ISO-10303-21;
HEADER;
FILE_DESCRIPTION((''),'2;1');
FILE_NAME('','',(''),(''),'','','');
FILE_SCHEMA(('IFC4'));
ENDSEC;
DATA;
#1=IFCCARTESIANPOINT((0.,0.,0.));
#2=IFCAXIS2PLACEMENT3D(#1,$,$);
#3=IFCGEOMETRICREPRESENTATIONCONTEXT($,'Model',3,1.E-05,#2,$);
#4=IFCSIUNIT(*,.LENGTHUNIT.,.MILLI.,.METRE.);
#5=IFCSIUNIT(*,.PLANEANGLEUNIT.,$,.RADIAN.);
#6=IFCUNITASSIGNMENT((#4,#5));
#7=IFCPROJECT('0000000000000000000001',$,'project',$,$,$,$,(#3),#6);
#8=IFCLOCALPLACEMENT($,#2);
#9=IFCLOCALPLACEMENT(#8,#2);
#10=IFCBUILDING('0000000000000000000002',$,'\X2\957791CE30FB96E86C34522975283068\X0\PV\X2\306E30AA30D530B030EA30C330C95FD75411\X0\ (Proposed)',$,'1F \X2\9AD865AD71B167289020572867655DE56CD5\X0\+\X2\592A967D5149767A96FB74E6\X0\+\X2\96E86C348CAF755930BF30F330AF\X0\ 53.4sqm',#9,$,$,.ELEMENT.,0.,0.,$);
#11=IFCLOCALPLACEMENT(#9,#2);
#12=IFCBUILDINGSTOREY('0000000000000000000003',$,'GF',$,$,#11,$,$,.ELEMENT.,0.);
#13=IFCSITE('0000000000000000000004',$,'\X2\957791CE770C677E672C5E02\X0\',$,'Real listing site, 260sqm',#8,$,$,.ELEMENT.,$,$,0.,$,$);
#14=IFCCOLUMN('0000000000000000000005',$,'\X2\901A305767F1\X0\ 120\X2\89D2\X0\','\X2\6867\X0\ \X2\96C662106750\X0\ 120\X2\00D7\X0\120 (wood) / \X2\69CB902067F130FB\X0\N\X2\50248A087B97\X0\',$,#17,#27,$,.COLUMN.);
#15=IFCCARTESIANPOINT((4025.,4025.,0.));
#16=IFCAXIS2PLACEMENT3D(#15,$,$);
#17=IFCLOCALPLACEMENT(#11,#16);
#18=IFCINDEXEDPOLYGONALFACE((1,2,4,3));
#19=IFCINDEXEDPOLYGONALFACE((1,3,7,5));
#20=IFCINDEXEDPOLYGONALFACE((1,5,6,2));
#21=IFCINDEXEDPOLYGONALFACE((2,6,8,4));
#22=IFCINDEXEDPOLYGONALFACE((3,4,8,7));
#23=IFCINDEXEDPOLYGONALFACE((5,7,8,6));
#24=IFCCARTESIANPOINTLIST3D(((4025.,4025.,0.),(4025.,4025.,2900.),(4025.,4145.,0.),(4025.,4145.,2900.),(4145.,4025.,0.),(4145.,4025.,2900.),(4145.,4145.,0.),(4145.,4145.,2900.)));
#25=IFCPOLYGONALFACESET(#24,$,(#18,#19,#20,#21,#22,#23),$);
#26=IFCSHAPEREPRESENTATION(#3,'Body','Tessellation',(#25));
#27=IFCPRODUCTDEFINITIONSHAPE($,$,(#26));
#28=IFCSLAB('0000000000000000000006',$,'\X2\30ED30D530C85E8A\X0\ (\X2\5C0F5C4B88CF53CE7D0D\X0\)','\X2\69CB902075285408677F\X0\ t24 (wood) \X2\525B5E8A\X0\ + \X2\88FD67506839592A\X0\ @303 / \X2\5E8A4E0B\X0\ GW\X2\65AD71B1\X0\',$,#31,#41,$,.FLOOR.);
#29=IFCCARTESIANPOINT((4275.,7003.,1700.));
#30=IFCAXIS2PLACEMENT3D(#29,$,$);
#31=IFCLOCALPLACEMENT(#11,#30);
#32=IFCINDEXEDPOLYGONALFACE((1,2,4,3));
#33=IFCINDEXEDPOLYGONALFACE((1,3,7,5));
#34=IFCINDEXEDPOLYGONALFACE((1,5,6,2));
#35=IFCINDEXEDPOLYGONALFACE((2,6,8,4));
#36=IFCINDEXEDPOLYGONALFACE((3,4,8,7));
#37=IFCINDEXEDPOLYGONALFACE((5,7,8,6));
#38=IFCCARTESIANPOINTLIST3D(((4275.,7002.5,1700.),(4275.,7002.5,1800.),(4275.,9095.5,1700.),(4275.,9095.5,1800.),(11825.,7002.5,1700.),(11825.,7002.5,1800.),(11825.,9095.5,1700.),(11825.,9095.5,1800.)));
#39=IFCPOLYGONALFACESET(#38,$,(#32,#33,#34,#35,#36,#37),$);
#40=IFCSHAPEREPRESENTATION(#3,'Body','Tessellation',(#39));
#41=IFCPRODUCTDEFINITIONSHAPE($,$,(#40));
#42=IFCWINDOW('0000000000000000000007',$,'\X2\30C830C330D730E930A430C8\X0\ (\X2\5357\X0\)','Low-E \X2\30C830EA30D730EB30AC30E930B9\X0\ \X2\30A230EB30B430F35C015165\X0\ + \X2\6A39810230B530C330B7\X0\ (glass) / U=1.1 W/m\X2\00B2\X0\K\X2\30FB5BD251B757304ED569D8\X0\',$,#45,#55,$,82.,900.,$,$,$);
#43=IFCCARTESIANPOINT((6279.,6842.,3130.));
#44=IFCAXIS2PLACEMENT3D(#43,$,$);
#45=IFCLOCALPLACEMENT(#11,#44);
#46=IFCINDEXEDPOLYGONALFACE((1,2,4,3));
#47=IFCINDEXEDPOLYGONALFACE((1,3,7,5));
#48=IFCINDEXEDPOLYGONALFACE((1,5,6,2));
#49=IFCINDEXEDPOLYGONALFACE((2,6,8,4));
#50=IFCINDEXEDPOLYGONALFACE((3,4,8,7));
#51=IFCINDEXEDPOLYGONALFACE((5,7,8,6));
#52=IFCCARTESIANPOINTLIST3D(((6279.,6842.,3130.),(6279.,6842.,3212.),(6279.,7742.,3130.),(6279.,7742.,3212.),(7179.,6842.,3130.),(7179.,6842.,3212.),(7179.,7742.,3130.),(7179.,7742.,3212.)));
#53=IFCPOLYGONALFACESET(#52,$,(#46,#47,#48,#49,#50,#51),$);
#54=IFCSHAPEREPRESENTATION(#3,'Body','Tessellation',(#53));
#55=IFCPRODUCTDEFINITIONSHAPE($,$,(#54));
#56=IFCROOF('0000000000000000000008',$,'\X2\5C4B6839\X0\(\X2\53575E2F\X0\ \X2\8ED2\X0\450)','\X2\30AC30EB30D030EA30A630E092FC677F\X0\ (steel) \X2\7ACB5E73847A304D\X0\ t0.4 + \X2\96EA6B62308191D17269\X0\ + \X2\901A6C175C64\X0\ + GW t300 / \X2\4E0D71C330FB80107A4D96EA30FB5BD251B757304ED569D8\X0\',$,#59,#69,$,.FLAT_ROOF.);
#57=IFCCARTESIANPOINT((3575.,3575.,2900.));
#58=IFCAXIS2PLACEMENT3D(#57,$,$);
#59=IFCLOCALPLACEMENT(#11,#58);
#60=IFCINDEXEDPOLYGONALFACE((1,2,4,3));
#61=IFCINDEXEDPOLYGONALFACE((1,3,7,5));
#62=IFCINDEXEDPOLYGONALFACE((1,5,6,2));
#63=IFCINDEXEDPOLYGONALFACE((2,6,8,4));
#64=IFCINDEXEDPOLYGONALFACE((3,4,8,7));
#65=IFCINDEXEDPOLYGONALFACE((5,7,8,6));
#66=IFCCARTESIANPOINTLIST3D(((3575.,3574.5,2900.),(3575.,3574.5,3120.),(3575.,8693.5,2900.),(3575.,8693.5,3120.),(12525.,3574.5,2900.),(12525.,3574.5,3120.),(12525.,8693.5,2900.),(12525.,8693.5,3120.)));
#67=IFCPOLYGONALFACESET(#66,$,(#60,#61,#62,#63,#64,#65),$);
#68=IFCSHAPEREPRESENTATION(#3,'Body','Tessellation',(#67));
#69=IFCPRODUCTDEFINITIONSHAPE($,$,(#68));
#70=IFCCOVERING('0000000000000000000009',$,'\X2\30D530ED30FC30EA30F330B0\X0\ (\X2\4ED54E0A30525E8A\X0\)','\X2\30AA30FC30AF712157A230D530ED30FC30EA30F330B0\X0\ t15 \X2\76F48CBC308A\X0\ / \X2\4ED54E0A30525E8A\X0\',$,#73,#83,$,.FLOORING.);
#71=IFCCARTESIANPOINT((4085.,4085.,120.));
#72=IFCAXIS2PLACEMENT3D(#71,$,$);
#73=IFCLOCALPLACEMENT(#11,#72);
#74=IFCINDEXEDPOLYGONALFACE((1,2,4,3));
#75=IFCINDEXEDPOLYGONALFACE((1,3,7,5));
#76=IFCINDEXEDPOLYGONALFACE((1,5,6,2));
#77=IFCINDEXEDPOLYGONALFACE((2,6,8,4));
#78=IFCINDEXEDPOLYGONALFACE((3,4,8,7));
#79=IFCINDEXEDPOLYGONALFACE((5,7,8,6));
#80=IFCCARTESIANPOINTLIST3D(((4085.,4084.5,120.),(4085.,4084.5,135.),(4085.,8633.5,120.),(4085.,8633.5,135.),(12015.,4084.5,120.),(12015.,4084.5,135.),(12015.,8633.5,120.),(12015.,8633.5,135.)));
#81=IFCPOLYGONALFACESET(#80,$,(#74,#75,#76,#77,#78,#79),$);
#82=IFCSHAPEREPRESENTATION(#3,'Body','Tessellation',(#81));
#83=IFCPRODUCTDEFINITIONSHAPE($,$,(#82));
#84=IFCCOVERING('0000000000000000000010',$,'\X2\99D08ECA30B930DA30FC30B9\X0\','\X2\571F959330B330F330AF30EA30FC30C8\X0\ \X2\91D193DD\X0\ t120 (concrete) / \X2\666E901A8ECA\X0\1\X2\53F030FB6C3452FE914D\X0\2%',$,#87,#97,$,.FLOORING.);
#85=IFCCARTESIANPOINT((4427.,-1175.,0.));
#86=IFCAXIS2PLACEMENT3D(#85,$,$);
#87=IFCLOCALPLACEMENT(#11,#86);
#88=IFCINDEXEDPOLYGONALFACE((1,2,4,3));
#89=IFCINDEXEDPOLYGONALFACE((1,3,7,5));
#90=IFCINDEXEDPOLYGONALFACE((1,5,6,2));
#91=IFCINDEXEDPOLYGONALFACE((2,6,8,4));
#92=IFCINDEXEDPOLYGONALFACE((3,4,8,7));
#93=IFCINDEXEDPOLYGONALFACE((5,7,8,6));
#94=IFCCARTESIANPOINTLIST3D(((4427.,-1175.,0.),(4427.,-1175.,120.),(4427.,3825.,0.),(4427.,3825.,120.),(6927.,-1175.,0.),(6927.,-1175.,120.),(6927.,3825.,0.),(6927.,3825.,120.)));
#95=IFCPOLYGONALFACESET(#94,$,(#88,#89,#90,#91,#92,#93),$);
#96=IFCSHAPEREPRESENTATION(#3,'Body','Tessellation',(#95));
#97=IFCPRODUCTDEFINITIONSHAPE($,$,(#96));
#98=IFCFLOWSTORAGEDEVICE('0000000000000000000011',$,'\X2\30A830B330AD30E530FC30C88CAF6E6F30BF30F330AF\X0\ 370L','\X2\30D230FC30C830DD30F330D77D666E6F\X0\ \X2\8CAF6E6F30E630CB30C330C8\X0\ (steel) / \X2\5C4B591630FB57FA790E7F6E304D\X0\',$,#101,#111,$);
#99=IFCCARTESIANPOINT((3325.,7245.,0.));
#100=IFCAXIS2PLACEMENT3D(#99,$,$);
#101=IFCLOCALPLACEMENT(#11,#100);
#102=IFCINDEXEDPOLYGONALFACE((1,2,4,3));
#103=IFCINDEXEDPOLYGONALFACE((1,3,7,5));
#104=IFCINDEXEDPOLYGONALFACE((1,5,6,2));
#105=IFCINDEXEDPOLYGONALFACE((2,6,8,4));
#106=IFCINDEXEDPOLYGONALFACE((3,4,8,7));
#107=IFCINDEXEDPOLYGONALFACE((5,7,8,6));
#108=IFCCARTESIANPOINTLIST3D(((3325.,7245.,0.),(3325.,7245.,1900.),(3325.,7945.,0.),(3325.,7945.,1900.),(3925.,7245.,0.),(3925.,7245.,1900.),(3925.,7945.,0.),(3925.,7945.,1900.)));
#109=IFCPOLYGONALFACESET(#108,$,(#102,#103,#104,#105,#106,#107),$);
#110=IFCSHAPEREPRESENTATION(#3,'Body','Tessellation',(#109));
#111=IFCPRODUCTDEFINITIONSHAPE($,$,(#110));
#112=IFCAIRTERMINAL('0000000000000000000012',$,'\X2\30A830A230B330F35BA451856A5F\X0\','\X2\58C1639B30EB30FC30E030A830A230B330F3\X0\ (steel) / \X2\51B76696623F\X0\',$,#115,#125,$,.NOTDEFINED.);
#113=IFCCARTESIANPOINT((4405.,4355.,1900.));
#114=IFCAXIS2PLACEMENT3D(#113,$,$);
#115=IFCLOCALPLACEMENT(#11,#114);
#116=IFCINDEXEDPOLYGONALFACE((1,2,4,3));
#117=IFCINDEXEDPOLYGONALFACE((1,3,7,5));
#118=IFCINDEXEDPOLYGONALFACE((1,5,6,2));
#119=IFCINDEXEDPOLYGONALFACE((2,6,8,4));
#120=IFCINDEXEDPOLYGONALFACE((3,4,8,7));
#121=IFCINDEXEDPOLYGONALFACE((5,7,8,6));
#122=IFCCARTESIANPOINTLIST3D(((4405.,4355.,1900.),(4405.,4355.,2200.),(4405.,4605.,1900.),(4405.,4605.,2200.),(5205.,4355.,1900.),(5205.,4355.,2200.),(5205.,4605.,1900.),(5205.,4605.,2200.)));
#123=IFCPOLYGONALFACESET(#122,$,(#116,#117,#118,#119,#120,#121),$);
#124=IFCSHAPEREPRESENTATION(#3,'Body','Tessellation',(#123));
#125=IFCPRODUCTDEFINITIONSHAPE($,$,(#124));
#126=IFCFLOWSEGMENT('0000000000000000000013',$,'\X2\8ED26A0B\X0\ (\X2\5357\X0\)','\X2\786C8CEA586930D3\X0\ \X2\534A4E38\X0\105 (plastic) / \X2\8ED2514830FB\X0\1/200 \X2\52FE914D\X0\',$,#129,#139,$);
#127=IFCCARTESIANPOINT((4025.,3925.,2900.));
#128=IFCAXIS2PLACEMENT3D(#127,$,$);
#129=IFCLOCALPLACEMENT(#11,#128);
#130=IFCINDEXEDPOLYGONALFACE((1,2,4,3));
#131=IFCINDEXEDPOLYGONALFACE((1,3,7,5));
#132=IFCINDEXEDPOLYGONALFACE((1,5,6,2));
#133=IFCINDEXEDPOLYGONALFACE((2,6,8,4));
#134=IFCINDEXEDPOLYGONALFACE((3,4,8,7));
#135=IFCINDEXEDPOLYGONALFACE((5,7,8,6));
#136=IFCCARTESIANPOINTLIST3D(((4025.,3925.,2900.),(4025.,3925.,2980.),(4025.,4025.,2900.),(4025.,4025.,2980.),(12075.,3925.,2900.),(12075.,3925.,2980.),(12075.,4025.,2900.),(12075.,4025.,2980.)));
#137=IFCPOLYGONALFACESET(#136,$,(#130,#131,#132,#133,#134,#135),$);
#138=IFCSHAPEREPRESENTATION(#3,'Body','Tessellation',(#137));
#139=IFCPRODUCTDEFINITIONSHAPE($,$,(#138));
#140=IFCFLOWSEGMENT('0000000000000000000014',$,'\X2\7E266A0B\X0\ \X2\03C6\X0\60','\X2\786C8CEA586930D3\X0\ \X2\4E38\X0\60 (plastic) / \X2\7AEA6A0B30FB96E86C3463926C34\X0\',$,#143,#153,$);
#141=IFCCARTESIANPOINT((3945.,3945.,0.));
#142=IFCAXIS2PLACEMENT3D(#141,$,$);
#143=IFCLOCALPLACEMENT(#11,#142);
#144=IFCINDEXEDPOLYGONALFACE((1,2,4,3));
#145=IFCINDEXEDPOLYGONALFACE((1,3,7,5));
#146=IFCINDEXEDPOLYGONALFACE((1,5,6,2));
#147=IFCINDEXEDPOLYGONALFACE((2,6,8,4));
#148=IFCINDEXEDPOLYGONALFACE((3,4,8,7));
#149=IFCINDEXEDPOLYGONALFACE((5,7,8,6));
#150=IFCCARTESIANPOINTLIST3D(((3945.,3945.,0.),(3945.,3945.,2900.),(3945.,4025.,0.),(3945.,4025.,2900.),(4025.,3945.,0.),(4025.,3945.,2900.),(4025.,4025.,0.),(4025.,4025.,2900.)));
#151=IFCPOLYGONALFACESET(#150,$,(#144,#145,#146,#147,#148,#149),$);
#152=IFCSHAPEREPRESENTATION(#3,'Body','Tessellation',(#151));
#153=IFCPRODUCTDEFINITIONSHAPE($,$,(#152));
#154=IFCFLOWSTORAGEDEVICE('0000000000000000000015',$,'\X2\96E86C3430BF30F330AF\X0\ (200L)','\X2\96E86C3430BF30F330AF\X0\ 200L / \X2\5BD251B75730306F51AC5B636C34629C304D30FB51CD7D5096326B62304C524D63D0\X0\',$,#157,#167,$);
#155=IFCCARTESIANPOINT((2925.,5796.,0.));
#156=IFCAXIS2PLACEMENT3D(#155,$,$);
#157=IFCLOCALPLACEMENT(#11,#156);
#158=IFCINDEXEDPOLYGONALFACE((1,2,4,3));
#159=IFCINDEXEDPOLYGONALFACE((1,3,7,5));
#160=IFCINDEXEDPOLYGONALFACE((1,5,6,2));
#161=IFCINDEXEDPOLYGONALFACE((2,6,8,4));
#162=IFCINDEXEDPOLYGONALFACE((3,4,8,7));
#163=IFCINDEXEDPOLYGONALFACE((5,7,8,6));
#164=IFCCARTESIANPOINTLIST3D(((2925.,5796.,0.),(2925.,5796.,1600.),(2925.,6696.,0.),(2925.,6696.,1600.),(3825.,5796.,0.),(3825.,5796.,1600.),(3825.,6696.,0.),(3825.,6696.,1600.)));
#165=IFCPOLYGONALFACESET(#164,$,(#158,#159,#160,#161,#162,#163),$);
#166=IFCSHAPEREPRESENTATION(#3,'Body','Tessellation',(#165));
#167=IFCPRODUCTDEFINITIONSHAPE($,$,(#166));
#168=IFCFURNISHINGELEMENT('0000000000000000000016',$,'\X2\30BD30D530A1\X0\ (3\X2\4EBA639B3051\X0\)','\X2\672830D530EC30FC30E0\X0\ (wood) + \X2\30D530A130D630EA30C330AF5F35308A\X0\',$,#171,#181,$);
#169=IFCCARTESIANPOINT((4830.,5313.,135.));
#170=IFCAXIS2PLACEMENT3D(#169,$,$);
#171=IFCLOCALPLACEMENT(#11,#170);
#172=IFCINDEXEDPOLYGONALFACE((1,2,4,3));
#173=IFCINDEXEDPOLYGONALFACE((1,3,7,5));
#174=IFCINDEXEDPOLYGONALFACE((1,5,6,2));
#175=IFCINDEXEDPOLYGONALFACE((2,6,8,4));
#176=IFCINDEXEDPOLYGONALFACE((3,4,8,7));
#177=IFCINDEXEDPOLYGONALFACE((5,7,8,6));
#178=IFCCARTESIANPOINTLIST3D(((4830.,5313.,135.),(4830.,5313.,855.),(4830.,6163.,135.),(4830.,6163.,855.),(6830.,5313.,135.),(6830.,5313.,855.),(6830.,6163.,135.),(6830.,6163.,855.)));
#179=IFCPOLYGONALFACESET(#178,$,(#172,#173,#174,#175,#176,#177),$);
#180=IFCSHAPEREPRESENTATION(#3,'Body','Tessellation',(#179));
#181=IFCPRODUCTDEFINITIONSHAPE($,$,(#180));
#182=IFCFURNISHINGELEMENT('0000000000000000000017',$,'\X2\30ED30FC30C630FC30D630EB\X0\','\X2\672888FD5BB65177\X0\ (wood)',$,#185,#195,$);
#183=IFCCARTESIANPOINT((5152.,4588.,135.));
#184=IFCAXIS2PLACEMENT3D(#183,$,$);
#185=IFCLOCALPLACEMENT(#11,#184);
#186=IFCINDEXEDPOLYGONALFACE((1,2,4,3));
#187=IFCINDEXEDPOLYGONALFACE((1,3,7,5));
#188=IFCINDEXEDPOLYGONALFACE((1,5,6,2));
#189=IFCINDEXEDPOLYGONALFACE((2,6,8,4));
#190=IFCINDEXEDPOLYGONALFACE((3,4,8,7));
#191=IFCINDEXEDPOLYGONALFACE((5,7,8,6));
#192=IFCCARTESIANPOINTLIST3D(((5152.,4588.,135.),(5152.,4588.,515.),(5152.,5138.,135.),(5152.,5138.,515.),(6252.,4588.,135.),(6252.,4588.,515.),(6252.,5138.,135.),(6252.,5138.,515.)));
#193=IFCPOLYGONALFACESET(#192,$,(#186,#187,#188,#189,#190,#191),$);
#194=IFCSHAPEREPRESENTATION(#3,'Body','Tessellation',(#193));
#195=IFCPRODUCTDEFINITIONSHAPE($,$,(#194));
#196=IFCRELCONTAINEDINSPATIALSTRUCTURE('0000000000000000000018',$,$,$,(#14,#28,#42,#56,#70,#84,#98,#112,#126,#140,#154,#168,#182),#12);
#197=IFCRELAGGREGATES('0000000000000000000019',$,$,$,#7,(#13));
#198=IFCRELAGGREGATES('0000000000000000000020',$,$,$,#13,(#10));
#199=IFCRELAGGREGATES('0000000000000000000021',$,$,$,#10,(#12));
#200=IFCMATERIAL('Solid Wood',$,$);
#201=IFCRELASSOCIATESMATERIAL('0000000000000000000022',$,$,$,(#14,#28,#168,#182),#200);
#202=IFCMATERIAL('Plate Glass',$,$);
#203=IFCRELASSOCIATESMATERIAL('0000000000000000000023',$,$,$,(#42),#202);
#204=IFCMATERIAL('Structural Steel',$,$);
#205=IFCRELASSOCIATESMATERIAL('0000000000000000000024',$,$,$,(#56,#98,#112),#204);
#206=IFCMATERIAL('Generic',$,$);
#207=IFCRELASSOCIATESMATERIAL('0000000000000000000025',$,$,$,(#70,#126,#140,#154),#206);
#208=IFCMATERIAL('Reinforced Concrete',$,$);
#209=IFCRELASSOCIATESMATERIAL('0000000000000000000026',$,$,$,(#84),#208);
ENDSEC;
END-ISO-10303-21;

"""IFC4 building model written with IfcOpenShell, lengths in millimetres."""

from ifc_helpers import new_model, si_unit, frame, frame_2d, origin, place, context, project, spatial, rectangle, extrude, material, element, save


model = new_model("IFC4")

# Units and contexts
model_context = context("Model", 3, precision=1e-05, world=origin())
ifc_project = project(units=[si_unit("LENGTHUNIT", "METRE", prefix="MILLI"), si_unit("PLANEANGLEUNIT", "RADIAN")], contexts=[model_context])

# Site, building, storey
site_placement = place(None, origin())
site = spatial("IfcSite", under=ifc_project, at=site_placement, Name="長野県松本市", ObjectType="Real listing site, 260sqm", CompositionType="ELEMENT", RefElevation=0.0)
building_placement = place(site_placement, origin())
building = spatial("IfcBuilding", under=site, at=building_placement, Name="長野・雨水利用とPVのオフグリッド志向 (Proposed)", ObjectType="1F 高断熱木造在来工法+太陽光発電瓦+雨水貯留タンク 53.4sqm", CompositionType="ELEMENT", ElevationOfRefHeight=0.0, ElevationOfTerrain=0.0)
storey_placement = place(building_placement, origin())
storey = spatial("IfcBuildingStorey", under=building, at=storey_placement, Name="GF", CompositionType="ELEMENT", Elevation=0.0)

# Column
ifc_material_1 = material(Name="Solid Wood")
column_1_placement = place(storey_placement, frame((4025.0, 4025.0, 0.0)))
element("IfcColumn", 1, at=column_1_placement, inside=storey, material=ifc_material_1, Name="通し柱 120角", Description="桧 集成材 120×120 (wood) / 構造柱・N値計算", PredefinedType="COLUMN", context=model_context, shape_type="SweptSolid", body=[
    extrude(rectangle(XDim=120.0, YDim=120.0, at=frame_2d((60.0, 60.0))), frame((4025.0, 4025.0, 0.0)), (0.0, 0.0, 1.0), 2900.0),
])

# Slab
ifc_material_2 = material(Name="Reinforced Concrete")
slab_1_placement = place(storey_placement, frame((4275.0, 7003.0, 1700.0)))
element("IfcSlab", 2, at=slab_1_placement, inside=storey, material=ifc_material_1, Name="ロフト床 (小屋裏収納)", Description="構造用合板 t24 (wood) 剛床 + 製材根太 @303 / 床下 GW断熱", PredefinedType="FLOOR", context=model_context, shape_type="SweptSolid", body=[
    extrude(rectangle(XDim=7550.0, YDim=2093.0, at=frame_2d((3775.0, 1046.0))), frame((4275.0, 7003.0, 1700.0)), (0.0, 0.0, 1.0), 100.0),
])

# Shared definitions
ifc_material_3 = material(Name="Plate Glass")

# Window
window_1_placement = place(storey_placement, frame((6279.0, 6842.0, 3130.0)))
element("IfcWindow", 3, at=window_1_placement, inside=storey, material=ifc_material_3, Name="トップライト (南)", Description="Low-E トリプルガラス アルゴン封入 + 樹脂サッシ (glass) / U=1.1 W/m²K・寒冷地仕様", OverallHeight=82.0, OverallWidth=900.0, context=model_context, shape_type="SweptSolid", body=[
    extrude(rectangle(XDim=900.0, YDim=900.0, at=frame_2d((450.0, 450.0))), frame((6279.0, 6842.0, 3130.0)), (0.0, 0.0, 1.0), 82.0),
])

# Roof
ifc_material_4 = material(Name="Structural Steel")
roof_placement = place(storey_placement, frame((3575.0, 3575.0, 2900.0)))
element("IfcRoof", 4, at=roof_placement, inside=storey, material=ifc_material_4, Name="屋根(南帯 軒450)", Description="ガルバリウム鋼板 (steel) 立平葺き t0.4 + 雪止め金物 + 通気層 + GW t300 / 不燃・耐積雪・寒冷地仕様", PredefinedType="FLAT_ROOF", context=model_context, shape_type="SweptSolid", body=[
    extrude(rectangle(XDim=8950.0, YDim=5119.0, at=frame_2d((4475.0, 2559.0))), frame((3575.0, 3575.0, 2900.0)), (0.0, 0.0, 1.0), 220.0),
])

# Coverings
ifc_material_5 = material(Name="Generic")
covering_1_placement = place(storey_placement, frame((4085.0, 4085.0, 120.0)))
element("IfcCovering", 5, at=covering_1_placement, inside=storey, material=ifc_material_5, Name="フローリング (仕上げ床)", Description="オーク無垢フローリング t15 直貼り / 仕上げ床", PredefinedType="FLOORING", context=model_context, shape_type="SweptSolid", body=[
    extrude(rectangle(XDim=7930.0, YDim=4549.0, at=frame_2d((3965.0, 2274.0))), frame((4085.0, 4085.0, 120.0)), (0.0, 0.0, 1.0), 15.0),
])
covering_2_placement = place(storey_placement, frame((4427.0, -1175.0, 0.0)))
element("IfcCovering", 6, at=covering_2_placement, inside=storey, material=ifc_material_2, Name="駐車スペース", Description="土間コンクリート 金鏝 t120 (concrete) / 普通車1台・水勾配2%", PredefinedType="FLOORING", context=model_context, shape_type="SweptSolid", body=[
    extrude(rectangle(XDim=2500.0, YDim=5000.0, at=frame_2d((1250.0, 2500.0))), frame((4427.0, -1175.0, 0.0)), (0.0, 0.0, 1.0), 120.0),
])

# Flow storage device
flow_storage_device_1_placement = place(storey_placement, frame((3325.0, 7245.0, 0.0)))
element("IfcFlowStorageDevice", 7, at=flow_storage_device_1_placement, inside=storey, material=ifc_material_4, Name="エコキュート貯湯タンク 370L", Description="ヒートポンプ給湯 貯湯ユニット (steel) / 屋外・基礎置き", context=model_context, shape_type="SweptSolid", body=[
    extrude(rectangle(XDim=600.0, YDim=700.0, at=frame_2d((300.0, 350.0))), frame((3325.0, 7245.0, 0.0)), (0.0, 0.0, 1.0), 1900.0),
])

# Air terminal
air_terminal_placement = place(storey_placement, frame((4405.0, 4355.0, 1900.0)))
element("IfcAirTerminal", 8, at=air_terminal_placement, inside=storey, material=ifc_material_4, Name="エアコン室内機", Description="壁掛ルームエアコン (steel) / 冷暖房", PredefinedType="NOTDEFINED", context=model_context, shape_type="SweptSolid", body=[
    extrude(rectangle(XDim=800.0, YDim=250.0, at=frame_2d((400.0, 125.0))), frame((4405.0, 4355.0, 1900.0)), (0.0, 0.0, 1.0), 300.0),
])

# Flow segments
flow_segment_1_placement = place(storey_placement, frame((4025.0, 3925.0, 2900.0)))
element("IfcFlowSegment", 9, at=flow_segment_1_placement, inside=storey, material=ifc_material_5, Name="軒樋 (南)", Description="硬質塩ビ 半丸105 (plastic) / 軒先・1/200 勾配", context=model_context, shape_type="SweptSolid", body=[
    extrude(rectangle(XDim=8050.0, YDim=100.0, at=frame_2d((4025.0, 50.0))), frame((4025.0, 3925.0, 2900.0)), (0.0, 0.0, 1.0), 80.0),
])
flow_segment_2_placement = place(storey_placement, frame((3945.0, 3945.0, 0.0)))
element("IfcFlowSegment", 10, at=flow_segment_2_placement, inside=storey, material=ifc_material_5, Name="縦樋 φ60", Description="硬質塩ビ 丸60 (plastic) / 竪樋・雨水排水", context=model_context, shape_type="SweptSolid", body=[
    extrude(rectangle(XDim=80.0, YDim=80.0, at=frame_2d((40.0, 40.0))), frame((3945.0, 3945.0, 0.0)), (0.0, 0.0, 1.0), 2900.0),
])

# Flow storage device
flow_storage_device_2_placement = place(storey_placement, frame((2925.0, 5796.0, 0.0)))
element("IfcFlowStorageDevice", 11, at=flow_storage_device_2_placement, inside=storey, material=ifc_material_5, Name="雨水タンク (200L)", Description="雨水タンク 200L / 寒冷地は冬季水抜き・凍結防止が前提", context=model_context, shape_type="SweptSolid", body=[
    extrude(rectangle(XDim=900.0, YDim=900.0, at=frame_2d((450.0, 450.0))), frame((2925.0, 5796.0, 0.0)), (0.0, 0.0, 1.0), 1600.0),
])

# Furnishing elements
furnishing_1_placement = place(storey_placement, frame((4830.0, 5313.0, 135.0)))
element("IfcFurnishingElement", 12, at=furnishing_1_placement, inside=storey, material=ifc_material_1, Name="ソファ (3人掛け)", Description="木フレーム (wood) + ファブリック張り", context=model_context, shape_type="SweptSolid", body=[
    extrude(rectangle(XDim=2000.0, YDim=850.0, at=frame_2d((1000.0, 425.0))), frame((4830.0, 5313.0, 135.0)), (0.0, 0.0, 1.0), 720.0),
])
furnishing_2_placement = place(storey_placement, frame((5152.0, 4588.0, 135.0)))
element("IfcFurnishingElement", 13, at=furnishing_2_placement, inside=storey, material=ifc_material_1, Name="ローテーブル", Description="木製家具 (wood)", context=model_context, shape_type="SweptSolid", body=[
    extrude(rectangle(XDim=1100.0, YDim=550.0, at=frame_2d((550.0, 275.0))), frame((5152.0, 4588.0, 135.0)), (0.0, 0.0, 1.0), 380.0),
])

save(model, "model.ifc")
